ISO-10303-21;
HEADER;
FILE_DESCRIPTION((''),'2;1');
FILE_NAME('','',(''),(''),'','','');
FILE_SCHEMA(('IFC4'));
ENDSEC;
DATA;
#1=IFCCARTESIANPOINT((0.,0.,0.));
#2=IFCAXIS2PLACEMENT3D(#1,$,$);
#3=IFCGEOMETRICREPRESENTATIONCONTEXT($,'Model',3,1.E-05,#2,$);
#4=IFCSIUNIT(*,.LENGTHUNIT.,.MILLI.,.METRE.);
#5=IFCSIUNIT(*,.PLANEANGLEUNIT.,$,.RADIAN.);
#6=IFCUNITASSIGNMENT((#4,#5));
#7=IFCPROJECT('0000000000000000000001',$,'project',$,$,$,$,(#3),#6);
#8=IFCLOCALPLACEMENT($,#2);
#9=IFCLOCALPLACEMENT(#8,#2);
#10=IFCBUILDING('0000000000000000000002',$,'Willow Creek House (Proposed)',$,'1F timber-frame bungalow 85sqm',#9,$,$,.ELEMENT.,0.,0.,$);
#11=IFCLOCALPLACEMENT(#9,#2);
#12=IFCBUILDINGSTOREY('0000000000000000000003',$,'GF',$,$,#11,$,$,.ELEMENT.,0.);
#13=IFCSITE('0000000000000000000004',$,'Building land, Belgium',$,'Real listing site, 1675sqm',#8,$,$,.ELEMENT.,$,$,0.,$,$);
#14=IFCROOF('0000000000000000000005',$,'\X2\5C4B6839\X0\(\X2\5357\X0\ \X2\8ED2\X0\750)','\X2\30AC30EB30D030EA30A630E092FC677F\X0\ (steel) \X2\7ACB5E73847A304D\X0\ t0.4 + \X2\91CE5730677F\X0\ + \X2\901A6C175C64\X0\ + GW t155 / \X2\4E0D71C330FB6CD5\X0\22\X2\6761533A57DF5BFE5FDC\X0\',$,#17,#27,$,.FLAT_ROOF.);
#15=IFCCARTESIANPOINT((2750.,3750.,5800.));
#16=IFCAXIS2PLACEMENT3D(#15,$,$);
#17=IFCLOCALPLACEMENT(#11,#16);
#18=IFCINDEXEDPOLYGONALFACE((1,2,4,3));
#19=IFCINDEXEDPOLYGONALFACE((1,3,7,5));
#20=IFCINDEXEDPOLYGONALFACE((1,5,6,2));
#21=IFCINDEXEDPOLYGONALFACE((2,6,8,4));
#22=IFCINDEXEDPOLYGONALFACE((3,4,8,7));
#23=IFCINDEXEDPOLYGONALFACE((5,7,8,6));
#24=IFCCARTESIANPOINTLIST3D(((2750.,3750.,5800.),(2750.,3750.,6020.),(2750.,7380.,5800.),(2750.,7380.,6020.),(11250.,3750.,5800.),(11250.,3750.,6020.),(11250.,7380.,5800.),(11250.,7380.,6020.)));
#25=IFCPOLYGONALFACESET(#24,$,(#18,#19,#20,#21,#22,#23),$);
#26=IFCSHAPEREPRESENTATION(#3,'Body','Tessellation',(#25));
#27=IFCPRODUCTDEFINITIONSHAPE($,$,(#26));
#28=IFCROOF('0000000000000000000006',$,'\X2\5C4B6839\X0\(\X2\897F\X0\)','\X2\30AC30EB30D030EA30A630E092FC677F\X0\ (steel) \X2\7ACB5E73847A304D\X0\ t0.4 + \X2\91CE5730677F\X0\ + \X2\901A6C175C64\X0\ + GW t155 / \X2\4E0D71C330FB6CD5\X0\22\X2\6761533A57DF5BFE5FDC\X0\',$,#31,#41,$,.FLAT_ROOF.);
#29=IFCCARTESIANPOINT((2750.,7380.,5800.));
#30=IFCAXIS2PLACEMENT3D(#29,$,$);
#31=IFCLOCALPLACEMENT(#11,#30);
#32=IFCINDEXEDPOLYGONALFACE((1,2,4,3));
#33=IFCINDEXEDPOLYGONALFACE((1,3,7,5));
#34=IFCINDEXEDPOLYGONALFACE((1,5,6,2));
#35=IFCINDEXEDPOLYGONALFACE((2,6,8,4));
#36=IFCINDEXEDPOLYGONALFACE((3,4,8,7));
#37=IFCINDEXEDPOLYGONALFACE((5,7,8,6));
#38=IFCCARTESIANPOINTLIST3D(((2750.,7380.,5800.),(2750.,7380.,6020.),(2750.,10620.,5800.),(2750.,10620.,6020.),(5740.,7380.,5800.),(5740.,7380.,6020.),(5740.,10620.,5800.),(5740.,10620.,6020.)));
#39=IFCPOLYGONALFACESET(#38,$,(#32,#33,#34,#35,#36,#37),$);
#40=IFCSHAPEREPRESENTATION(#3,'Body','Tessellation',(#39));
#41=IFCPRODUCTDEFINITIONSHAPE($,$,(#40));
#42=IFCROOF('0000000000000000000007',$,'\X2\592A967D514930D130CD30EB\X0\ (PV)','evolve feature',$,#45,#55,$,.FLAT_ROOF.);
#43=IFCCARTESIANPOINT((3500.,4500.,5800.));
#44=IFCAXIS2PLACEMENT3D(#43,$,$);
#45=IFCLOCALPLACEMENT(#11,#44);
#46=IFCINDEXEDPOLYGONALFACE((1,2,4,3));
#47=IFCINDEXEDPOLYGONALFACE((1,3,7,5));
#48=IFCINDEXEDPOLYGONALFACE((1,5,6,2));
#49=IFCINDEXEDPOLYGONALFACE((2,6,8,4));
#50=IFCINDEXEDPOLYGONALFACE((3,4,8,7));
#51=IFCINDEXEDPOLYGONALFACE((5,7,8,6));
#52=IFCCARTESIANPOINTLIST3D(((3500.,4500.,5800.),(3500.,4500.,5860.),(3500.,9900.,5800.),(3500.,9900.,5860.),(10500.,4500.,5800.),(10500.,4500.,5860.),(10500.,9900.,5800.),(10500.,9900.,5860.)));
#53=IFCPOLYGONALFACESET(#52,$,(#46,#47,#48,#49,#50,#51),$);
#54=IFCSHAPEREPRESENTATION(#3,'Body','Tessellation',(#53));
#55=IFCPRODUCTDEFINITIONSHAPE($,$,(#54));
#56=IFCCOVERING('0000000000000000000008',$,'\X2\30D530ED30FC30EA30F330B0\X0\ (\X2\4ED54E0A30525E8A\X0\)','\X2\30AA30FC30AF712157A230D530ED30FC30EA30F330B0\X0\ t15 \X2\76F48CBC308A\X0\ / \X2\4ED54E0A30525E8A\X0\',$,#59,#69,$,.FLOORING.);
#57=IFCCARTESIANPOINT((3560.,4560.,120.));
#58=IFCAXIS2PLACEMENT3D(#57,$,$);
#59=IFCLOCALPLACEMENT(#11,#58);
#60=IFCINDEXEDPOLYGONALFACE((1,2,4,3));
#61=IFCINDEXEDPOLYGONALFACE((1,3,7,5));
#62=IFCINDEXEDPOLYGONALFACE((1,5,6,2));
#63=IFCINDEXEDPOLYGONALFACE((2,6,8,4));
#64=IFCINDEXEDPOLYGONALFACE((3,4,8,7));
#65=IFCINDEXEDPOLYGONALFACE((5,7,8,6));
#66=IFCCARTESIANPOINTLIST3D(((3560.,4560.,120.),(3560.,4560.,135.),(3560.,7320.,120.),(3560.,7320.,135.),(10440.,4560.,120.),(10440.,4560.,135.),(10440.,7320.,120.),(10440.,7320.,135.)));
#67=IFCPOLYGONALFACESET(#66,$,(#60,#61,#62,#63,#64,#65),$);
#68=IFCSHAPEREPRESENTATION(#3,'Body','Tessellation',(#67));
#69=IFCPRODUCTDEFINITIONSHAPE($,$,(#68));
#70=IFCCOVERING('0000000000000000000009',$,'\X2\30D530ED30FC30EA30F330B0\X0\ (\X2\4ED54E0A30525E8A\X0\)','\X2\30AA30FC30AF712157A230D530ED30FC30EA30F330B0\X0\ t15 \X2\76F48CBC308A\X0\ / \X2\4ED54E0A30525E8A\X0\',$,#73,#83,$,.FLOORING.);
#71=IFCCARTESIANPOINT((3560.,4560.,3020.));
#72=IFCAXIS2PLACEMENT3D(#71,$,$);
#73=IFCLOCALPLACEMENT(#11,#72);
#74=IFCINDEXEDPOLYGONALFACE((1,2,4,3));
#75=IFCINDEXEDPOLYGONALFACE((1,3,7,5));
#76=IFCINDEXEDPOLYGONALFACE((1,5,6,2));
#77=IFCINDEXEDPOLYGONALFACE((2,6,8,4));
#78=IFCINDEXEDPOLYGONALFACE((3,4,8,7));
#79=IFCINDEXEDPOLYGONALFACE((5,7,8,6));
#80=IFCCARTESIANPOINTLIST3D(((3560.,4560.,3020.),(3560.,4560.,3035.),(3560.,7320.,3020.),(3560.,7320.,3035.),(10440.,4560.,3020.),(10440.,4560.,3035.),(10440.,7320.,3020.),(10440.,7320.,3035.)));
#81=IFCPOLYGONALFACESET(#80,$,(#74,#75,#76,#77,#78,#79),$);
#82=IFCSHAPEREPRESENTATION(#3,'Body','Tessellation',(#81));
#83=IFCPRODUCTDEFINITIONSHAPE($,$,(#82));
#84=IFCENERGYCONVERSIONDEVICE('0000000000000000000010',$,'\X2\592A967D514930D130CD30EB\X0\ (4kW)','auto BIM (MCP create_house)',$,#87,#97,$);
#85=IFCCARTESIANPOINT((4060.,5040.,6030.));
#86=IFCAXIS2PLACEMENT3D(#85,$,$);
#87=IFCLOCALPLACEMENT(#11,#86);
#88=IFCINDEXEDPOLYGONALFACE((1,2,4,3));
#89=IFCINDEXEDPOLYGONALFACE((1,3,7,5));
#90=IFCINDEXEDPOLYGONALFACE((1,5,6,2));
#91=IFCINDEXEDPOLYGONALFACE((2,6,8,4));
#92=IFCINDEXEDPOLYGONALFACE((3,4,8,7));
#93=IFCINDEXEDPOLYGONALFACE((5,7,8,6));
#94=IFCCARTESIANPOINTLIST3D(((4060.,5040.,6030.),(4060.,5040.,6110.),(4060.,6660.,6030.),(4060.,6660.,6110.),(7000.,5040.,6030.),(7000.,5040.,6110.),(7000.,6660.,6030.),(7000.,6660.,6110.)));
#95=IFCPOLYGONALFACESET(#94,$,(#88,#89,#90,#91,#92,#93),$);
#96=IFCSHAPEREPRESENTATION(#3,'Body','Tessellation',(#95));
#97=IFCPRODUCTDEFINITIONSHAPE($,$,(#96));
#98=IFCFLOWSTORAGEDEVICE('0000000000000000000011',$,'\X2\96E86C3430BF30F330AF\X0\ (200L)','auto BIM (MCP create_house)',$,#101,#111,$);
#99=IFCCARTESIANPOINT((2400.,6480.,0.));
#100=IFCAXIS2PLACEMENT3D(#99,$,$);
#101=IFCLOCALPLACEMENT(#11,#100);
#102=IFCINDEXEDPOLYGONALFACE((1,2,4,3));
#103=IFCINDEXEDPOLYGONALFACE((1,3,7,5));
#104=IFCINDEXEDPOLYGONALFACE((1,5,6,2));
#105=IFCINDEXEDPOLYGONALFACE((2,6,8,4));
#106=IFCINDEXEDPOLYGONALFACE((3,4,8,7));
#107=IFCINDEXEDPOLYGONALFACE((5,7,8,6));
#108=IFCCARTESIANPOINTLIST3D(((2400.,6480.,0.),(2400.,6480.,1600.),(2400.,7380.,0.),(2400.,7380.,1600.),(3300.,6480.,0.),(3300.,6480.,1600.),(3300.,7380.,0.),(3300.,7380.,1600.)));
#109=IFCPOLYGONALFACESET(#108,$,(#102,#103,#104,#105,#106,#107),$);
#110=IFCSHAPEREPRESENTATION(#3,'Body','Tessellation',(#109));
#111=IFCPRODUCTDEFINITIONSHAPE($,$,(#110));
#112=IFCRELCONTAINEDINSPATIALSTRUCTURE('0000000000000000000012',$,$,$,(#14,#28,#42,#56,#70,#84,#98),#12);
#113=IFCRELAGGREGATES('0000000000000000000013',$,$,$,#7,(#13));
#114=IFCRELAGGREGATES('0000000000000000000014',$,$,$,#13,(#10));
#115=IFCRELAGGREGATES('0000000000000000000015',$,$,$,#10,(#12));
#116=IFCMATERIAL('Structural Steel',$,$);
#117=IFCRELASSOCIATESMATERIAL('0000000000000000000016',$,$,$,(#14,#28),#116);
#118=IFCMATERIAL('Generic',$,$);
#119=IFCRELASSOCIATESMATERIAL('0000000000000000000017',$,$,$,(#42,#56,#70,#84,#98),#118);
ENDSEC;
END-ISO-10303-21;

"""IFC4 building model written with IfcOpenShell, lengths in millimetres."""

from ifc_helpers import new_model, si_unit, frame, frame_2d, origin, place, context, project, spatial, rectangle, extrude, material, element, save


model = new_model("IFC4")

# Units and contexts
model_context = context("Model", 3, precision=1e-05, world=origin())
ifc_project = project(units=[si_unit("LENGTHUNIT", "METRE", prefix="MILLI"), si_unit("PLANEANGLEUNIT", "RADIAN")], contexts=[model_context])

# Site, building, storey
site_placement = place(None, origin())
site = spatial("IfcSite", under=ifc_project, at=site_placement, Name="Building land, Belgium", ObjectType="Real listing site, 1675sqm", CompositionType="ELEMENT", RefElevation=0.0)
building_placement = place(site_placement, origin())
building = spatial("IfcBuilding", under=site, at=building_placement, Name="Willow Creek House (Proposed)", ObjectType="1F timber-frame bungalow 85sqm", CompositionType="ELEMENT", ElevationOfRefHeight=0.0, ElevationOfTerrain=0.0)
storey_placement = place(building_placement, origin())
storey = spatial("IfcBuildingStorey", under=building, at=storey_placement, Name="GF", CompositionType="ELEMENT", Elevation=0.0)

# Shared definitions
ifc_material_1 = material(Name="Generic")

# Roofs
ifc_material_2 = material(Name="Structural Steel")
roof_1_placement = place(storey_placement, frame((2750.0, 3750.0, 5800.0)))
element("IfcRoof", 1, at=roof_1_placement, inside=storey, material=ifc_material_2, Name="屋根(南 軒750)", Description="ガルバリウム鋼板 (steel) 立平葺き t0.4 + 野地板 + 通気層 + GW t155 / 不燃・法22条区域対応", PredefinedType="FLAT_ROOF", context=model_context, shape_type="SweptSolid", body=[
    extrude(rectangle(XDim=8500.0, YDim=3630.0, at=frame_2d((4250.0, 1815.0))), frame((2750.0, 3750.0, 5800.0)), (0.0, 0.0, 1.0), 220.0),
])
roof_2_placement = place(storey_placement, frame((2750.0, 7380.0, 5800.0)))
element("IfcRoof", 2, at=roof_2_placement, inside=storey, material=ifc_material_2, Name="屋根(西)", Description="ガルバリウム鋼板 (steel) 立平葺き t0.4 + 野地板 + 通気層 + GW t155 / 不燃・法22条区域対応", PredefinedType="FLAT_ROOF", context=model_context, shape_type="SweptSolid", body=[
    extrude(rectangle(XDim=2990.0, YDim=3240.0, at=frame_2d((1495.0, 1620.0))), frame((2750.0, 7380.0, 5800.0)), (0.0, 0.0, 1.0), 220.0),
])
roof_3_placement = place(storey_placement, frame((3500.0, 4500.0, 5800.0)))
element("IfcRoof", 3, at=roof_3_placement, inside=storey, material=ifc_material_1, Name="太陽光パネル (PV)", Description="evolve feature", PredefinedType="FLAT_ROOF", context=model_context, shape_type="SweptSolid", body=[
    extrude(rectangle(XDim=7000.0, YDim=5400.0, at=frame_2d((3500.0, 2700.0))), frame((3500.0, 4500.0, 5800.0)), (0.0, 0.0, 1.0), 60.0),
])

# Coverings
covering_1_placement = place(storey_placement, frame((3560.0, 4560.0, 120.0)))
element("IfcCovering", 4, at=covering_1_placement, inside=storey, material=ifc_material_1, Name="フローリング (仕上げ床)", Description="オーク無垢フローリング t15 直貼り / 仕上げ床", PredefinedType="FLOORING", context=model_context, shape_type="SweptSolid", body=[
    extrude(rectangle(XDim=6880.0, YDim=2760.0, at=frame_2d((3440.0, 1380.0))), frame((3560.0, 4560.0, 120.0)), (0.0, 0.0, 1.0), 15.0),
])
covering_2_placement = place(storey_placement, frame((3560.0, 4560.0, 3020.0)))
element("IfcCovering", 5, at=covering_2_placement, inside=storey, material=ifc_material_1, Name="フローリング (仕上げ床)", Description="オーク無垢フローリング t15 直貼り / 仕上げ床", PredefinedType="FLOORING", context=model_context, shape_type="SweptSolid", body=[
    extrude(rectangle(XDim=6880.0, YDim=2760.0, at=frame_2d((3440.0, 1380.0))), frame((3560.0, 4560.0, 3020.0)), (0.0, 0.0, 1.0), 15.0),
])

# Energy conversion device
energy_conversion_device_placement = place(storey_placement, frame((4060.0, 5040.0, 6030.0)))
element("IfcEnergyConversionDevice", 6, at=energy_conversion_device_placement, inside=storey, material=ifc_material_1, Name="太陽光パネル (4kW)", Description="auto BIM (MCP create_house)", context=model_context, shape_type="SweptSolid", body=[
    extrude(rectangle(XDim=2940.0, YDim=1620.0, at=frame_2d((1470.0, 810.0))), frame((4060.0, 5040.0, 6030.0)), (0.0, 0.0, 1.0), 80.0),
])

# Flow storage device
flow_storage_device_placement = place(storey_placement, frame((2400.0, 6480.0, 0.0)))
element("IfcFlowStorageDevice", 7, at=flow_storage_device_placement, inside=storey, material=ifc_material_1, Name="雨水タンク (200L)", Description="auto BIM (MCP create_house)", context=model_context, shape_type="SweptSolid", body=[
    extrude(rectangle(XDim=900.0, YDim=900.0, at=frame_2d((450.0, 450.0))), frame((2400.0, 6480.0, 0.0)), (0.0, 0.0, 1.0), 1600.0),
])

save(model, "model.ifc")
